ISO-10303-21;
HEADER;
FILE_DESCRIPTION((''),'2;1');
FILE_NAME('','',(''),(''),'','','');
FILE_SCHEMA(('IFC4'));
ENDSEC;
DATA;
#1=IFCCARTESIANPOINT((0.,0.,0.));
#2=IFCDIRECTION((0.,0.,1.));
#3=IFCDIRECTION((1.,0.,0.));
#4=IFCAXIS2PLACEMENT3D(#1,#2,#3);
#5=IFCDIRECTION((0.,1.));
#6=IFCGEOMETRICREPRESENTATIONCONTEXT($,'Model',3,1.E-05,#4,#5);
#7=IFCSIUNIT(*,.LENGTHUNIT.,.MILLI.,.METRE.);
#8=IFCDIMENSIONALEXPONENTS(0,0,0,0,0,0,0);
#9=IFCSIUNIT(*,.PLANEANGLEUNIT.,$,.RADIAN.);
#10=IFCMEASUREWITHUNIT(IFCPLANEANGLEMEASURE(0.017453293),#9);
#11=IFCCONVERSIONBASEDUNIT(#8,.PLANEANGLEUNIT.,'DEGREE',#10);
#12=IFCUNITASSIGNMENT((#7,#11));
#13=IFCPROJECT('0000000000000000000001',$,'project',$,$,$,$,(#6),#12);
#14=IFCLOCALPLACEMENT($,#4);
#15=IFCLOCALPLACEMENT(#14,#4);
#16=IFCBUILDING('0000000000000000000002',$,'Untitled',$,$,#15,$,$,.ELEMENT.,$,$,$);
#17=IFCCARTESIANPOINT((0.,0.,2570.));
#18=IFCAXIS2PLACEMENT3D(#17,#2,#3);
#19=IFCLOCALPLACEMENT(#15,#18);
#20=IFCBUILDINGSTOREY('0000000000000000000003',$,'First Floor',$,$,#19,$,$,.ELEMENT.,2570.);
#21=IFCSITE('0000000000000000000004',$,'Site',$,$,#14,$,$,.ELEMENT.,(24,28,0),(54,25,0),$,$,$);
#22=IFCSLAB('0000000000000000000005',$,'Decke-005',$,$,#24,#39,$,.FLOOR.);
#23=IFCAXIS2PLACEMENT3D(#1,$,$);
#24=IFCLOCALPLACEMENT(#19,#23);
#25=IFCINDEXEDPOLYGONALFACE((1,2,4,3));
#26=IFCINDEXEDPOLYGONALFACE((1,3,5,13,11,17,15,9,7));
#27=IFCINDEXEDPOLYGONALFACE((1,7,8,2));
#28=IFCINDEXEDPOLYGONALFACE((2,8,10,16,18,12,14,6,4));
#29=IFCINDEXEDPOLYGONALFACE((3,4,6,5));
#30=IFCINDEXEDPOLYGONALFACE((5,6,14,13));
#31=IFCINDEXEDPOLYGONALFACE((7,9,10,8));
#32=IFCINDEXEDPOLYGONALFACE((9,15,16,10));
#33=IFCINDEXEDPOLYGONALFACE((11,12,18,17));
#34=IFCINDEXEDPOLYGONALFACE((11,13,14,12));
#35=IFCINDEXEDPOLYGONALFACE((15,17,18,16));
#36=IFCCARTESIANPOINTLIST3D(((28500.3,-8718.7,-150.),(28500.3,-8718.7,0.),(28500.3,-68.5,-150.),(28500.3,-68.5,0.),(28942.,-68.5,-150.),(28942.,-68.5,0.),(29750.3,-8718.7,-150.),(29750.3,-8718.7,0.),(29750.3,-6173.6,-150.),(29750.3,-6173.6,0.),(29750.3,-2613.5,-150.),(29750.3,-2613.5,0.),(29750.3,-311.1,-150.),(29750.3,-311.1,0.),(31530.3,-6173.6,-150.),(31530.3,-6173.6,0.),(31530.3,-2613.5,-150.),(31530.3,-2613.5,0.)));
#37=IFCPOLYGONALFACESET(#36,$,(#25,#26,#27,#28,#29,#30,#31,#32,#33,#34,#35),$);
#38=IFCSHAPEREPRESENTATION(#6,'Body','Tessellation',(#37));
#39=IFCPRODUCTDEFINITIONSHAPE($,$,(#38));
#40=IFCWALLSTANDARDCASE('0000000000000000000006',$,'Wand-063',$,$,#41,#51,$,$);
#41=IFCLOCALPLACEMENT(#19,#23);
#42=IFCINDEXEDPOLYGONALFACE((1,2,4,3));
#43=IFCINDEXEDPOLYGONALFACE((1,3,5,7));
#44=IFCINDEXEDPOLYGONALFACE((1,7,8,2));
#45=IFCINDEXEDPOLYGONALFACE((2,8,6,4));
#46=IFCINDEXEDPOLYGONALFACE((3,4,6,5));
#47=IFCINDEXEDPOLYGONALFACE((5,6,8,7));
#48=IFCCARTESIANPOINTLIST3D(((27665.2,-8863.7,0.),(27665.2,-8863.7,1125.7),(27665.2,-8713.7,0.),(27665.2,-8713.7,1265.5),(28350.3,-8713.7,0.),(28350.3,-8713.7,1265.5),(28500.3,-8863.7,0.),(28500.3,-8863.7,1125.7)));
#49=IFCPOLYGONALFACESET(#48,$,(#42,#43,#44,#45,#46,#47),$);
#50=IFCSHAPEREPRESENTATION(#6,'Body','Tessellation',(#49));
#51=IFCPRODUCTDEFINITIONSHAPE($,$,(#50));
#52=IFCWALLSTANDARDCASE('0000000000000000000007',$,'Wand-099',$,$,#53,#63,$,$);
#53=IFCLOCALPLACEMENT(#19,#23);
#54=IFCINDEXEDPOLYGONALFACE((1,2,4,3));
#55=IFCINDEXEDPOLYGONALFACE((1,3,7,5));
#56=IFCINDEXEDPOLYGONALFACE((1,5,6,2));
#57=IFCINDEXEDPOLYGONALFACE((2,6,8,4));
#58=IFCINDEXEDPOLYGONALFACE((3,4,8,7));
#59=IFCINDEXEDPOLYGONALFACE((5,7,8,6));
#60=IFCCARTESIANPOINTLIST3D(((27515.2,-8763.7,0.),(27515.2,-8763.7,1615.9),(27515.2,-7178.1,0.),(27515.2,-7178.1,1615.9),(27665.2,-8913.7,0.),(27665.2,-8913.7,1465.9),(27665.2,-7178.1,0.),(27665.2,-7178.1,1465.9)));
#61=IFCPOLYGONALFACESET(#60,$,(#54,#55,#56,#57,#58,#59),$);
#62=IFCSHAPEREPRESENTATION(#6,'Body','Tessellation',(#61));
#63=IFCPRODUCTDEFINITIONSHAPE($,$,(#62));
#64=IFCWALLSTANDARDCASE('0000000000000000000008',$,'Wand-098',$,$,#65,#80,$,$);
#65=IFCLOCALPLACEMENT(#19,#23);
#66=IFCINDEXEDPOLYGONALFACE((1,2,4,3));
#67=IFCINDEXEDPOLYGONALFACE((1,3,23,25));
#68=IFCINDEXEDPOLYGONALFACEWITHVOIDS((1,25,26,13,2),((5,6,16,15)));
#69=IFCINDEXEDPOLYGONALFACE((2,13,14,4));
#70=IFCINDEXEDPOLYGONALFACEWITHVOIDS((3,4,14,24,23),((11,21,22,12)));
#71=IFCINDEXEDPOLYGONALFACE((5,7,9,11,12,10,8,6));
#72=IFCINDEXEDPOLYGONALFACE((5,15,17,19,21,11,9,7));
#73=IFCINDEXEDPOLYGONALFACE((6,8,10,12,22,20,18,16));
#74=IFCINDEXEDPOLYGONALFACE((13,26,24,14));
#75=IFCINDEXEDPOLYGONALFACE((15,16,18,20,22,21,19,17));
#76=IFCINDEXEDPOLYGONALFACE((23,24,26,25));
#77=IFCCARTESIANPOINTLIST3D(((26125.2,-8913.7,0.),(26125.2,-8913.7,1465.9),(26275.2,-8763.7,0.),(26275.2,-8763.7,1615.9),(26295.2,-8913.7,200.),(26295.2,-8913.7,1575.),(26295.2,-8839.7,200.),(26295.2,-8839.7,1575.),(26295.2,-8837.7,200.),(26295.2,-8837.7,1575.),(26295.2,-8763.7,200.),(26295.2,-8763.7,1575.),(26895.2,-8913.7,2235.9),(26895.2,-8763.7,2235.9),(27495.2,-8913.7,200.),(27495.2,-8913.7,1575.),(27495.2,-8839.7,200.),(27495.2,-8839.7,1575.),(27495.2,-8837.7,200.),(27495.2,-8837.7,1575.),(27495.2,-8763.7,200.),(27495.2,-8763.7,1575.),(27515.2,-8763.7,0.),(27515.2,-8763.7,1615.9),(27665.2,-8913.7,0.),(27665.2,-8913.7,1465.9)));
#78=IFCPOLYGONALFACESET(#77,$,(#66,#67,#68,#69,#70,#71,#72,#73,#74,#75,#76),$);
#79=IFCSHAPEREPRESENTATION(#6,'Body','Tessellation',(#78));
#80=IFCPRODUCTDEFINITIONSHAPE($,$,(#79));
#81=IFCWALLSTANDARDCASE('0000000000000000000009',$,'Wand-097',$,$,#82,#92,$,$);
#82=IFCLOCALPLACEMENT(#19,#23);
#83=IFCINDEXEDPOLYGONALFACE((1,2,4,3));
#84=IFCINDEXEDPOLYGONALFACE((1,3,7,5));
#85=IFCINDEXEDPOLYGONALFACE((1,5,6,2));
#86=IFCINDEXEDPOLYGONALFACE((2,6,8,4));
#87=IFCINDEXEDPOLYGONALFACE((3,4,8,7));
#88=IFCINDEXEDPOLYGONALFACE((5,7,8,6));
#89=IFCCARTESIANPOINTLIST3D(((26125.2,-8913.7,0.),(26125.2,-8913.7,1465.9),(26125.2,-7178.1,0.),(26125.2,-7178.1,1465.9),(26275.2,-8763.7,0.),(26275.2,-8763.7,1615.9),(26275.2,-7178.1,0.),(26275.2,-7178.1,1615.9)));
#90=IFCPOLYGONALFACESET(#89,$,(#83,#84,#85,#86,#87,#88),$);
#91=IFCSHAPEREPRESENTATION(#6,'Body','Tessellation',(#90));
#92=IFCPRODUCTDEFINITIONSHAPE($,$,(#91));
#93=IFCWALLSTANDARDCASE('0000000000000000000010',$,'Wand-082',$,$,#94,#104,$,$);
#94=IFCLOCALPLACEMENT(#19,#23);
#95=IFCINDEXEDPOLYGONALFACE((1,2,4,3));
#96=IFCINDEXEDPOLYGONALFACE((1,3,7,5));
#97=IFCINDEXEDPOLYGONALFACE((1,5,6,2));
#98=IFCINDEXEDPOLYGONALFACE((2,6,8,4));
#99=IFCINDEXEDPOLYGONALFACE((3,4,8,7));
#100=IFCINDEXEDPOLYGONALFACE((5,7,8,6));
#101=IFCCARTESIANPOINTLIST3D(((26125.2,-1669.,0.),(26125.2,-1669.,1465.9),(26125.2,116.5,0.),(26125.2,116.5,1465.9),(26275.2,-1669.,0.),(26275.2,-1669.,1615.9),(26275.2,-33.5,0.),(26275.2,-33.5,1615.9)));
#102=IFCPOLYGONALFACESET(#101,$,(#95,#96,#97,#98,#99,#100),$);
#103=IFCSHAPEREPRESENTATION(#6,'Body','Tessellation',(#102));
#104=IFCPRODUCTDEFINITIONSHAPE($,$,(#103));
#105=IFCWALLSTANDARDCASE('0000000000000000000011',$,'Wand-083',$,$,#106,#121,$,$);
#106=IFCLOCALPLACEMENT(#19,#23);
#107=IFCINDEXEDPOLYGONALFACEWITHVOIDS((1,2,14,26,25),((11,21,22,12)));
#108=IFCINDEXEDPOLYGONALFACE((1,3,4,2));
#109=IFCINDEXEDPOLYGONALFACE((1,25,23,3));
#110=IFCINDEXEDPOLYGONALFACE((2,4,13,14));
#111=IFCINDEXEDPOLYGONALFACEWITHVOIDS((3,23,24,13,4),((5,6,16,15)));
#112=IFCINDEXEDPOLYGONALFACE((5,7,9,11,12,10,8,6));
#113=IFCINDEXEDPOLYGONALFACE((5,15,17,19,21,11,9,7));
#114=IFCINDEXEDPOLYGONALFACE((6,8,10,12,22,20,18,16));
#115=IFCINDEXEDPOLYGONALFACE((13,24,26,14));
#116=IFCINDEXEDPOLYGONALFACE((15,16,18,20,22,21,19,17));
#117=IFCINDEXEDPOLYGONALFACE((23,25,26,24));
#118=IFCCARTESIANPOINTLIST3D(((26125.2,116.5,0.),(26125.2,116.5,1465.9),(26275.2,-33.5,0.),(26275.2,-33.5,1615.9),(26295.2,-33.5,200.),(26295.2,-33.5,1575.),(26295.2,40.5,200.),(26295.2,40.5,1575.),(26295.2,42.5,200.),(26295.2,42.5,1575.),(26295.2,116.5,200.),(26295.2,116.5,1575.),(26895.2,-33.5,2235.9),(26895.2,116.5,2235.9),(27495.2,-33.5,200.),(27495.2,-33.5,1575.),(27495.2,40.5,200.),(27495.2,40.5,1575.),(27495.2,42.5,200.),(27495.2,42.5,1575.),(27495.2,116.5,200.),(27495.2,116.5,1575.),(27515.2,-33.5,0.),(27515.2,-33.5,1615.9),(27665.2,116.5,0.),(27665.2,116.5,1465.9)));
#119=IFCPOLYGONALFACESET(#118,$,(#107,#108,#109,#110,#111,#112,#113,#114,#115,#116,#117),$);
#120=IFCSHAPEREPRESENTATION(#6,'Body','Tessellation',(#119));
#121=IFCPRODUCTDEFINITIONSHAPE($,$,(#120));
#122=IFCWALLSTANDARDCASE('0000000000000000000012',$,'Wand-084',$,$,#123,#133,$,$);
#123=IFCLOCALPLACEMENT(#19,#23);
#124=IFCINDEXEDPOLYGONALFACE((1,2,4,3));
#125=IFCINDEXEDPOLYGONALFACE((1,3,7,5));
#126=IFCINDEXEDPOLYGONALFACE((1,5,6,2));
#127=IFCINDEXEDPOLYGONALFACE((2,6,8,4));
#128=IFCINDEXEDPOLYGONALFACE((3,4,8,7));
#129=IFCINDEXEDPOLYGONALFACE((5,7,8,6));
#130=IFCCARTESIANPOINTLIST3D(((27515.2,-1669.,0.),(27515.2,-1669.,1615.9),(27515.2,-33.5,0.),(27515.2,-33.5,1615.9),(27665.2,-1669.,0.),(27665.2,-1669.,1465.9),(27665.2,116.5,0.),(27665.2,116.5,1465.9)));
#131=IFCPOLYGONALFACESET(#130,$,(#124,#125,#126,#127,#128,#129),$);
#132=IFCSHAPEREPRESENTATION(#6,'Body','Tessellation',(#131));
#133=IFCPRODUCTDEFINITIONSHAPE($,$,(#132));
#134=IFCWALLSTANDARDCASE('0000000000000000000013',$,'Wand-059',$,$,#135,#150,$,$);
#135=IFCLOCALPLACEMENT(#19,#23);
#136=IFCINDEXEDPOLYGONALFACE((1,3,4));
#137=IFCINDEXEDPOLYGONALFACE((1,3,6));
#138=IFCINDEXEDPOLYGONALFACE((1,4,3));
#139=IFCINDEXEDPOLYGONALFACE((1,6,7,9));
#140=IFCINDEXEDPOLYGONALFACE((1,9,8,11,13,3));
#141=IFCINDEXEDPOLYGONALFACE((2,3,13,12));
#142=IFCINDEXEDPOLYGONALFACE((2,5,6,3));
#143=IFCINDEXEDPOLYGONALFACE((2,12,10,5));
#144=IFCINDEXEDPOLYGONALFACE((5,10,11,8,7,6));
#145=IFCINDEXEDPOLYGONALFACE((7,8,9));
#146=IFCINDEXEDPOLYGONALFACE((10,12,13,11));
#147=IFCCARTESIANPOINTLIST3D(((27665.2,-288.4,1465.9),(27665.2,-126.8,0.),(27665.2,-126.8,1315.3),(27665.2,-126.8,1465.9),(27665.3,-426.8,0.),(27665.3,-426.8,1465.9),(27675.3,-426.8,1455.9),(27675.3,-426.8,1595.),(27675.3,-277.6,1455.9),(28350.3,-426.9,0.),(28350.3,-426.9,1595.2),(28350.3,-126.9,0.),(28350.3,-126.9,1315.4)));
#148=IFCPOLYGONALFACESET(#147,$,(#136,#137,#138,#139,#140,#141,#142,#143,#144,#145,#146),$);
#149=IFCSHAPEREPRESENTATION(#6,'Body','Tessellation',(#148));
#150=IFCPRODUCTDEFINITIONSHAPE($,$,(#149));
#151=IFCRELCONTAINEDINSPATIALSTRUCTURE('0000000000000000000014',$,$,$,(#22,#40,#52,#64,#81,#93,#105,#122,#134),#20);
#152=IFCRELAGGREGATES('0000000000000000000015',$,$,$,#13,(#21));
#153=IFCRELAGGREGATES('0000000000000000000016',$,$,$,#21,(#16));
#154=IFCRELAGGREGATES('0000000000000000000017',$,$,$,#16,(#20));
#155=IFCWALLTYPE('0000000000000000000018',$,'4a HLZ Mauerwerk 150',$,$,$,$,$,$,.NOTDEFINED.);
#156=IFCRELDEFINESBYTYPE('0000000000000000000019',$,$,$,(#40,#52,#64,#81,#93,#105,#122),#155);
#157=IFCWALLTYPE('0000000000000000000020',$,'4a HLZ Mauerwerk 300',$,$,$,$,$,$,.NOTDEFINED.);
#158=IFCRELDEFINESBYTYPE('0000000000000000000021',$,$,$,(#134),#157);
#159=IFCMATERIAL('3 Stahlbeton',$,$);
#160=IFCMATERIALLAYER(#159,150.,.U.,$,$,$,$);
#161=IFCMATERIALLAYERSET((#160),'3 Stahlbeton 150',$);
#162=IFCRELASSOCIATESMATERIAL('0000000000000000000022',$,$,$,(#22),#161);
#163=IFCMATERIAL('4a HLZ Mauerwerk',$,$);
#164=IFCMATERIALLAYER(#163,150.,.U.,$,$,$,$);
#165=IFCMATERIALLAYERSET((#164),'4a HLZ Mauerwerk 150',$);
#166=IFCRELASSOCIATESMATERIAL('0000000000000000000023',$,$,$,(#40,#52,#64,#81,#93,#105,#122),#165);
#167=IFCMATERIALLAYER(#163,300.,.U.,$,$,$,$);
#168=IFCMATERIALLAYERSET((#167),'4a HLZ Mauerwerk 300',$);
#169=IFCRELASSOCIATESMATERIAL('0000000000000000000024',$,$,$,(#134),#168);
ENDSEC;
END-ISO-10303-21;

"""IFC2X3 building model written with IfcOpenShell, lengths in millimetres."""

from ifc_helpers import new_model, entity, si_unit, converted_unit, direction, frame, origin_with_axes, origin_2d_with_axis, place, context, project, spatial, polyline, rectangle, outline, extrude, clip, halfspace, bounded_halfspace, material, layer, layer_set, layer_usage, type_object, element, save


model = new_model("IFC2X3")

# Units and contexts
model_context = context("Model", 3, precision=1e-05, world=origin_with_axes(), true_north=direction((0.0, 1.0)))
ifc_project = project(units=[si_unit("LENGTHUNIT", "METRE", prefix="MILLI"), converted_unit("PLANEANGLEUNIT", "DEGREE", entity("IfcPlaneAngleMeasure", 0.017453293), si_unit("PLANEANGLEUNIT", "RADIAN"), dimensions=[0, 0, 0, 0, 0, 0, 0])], contexts=[model_context])

# Site, building, storey
site_placement = place(None, origin_with_axes())
site = spatial("IfcSite", under=ifc_project, at=site_placement, Name="Site", CompositionType="ELEMENT", RefLatitude=(24, 28, 0), RefLongitude=(54, 25, 0))
building_placement = place(site_placement, origin_with_axes())
building = spatial("IfcBuilding", under=site, at=building_placement, Name="Untitled", CompositionType="ELEMENT")
storey_placement = place(building_placement, frame((0.0, 0.0, 2570.0), z_axis=(0.0, 0.0, 1.0), x_axis=(1.0, 0.0, 0.0)))
storey = spatial("IfcBuildingStorey", under=building, at=storey_placement, Name="First Floor", CompositionType="ELEMENT", Elevation=2570.0)

# Shared definitions
ifc_material_1 = material(Name="3 Stahlbeton")

# Slab
ifc_layer_1 = layer(ifc_material_1, 150.0, ventilated="UNKNOWN")
ifc_layer_set_1 = layer_set([ifc_layer_1], Name="3 Stahlbeton 150")
ifc_layer_usage_1 = layer_usage(ifc_layer_set_1, "AXIS3", "NEGATIVE", 150.0)
slab_placement = place(storey_placement, frame((28500.3, -68.5, -150.0), z_axis=(0.0, 0.0, 1.0), x_axis=(1.0, 0.0, 0.0)))
element("IfcSlab", 1, at=slab_placement, inside=storey, material=ifc_layer_usage_1, Name="Decke-005", PredefinedType="FLOOR", context=model_context, shape_type="SweptSolid", body=[
    extrude(outline(polyline([(0.0, 0.0), (0.0, -8650.2), (1250.0, -8650.2), (1250.0, -6105.1), (3030.1, -6105.1), (3030.1, -2545.1), (1250.0, -2545.1), (1250.0, -242.6), (441.7, 0.0), (0.0, 0.0)])), origin_with_axes(), (0.0, 0.0, 1.0), 150.0),
])

# Wall
ifc_material_2 = material(Name="4a HLZ Mauerwerk")
ifc_layer_2 = layer(ifc_material_2, 150.0, ventilated="UNKNOWN")
ifc_layer_set_2 = layer_set([ifc_layer_2], Name="4a HLZ Mauerwerk 150")
ifc_layer_usage_2 = layer_usage(ifc_layer_set_2, "AXIS2", "POSITIVE", 0.0)
wall_type_1 = type_object("IfcWallType", Name="4a HLZ Mauerwerk 150", PredefinedType="NOTDEFINED")
wall_1_placement = place(storey_placement, frame((27665.2, -8863.7, 0.0), z_axis=(0.0, 0.0, 1.0), x_axis=(1.0, 0.0, 0.0)))
element("IfcWallStandardCase", 2, at=wall_1_placement, inside=storey, type_object=wall_type_1, material=ifc_layer_usage_2, Name="Wand-063", context=model_context, shape_type="Clipping", body=[
    clip(extrude(outline(polyline([(0.0, 0.0), (835.0, 0.0), (685.0, 150.0), (0.0, 150.0), (0.0, 0.0)])), origin_with_axes(), (0.0, 0.0, 1.0), 5316.0), bounded_halfspace(frame((0.0, -561.5, 602.1), z_axis=(0.0, 0.681998, -0.731354), x_axis=(0.0, -0.731354, -0.681998)), True, origin_with_axes(), polyline([(0.0, 0.0), (835.0, 0.0), (835.0, 150.0), (0.0, 150.0), (0.0, 0.0)]))),
])

# Wall
ifc_layer_usage_3 = layer_usage(ifc_layer_set_2, "AXIS2", "POSITIVE", 0.0)
wall_2_placement = place(storey_placement, frame((27665.2, -8913.7, 0.0), z_axis=(0.0, 0.0, 1.0), x_axis=(0.0, 1.0, 0.0)))
element("IfcWallStandardCase", 3, at=wall_2_placement, inside=storey, type_object=wall_type_1, material=ifc_layer_usage_3, Name="Wand-099", context=model_context, shape_type="Clipping", body=[
    clip(extrude(outline(polyline([(0.0, 0.0), (1735.6, 0.0), (1735.6, 150.0), (150.0, 150.0), (0.0, 0.0)])), origin_with_axes(), (0.0, 0.0, 1.0), 5316.0), halfspace(frame((0.0, -733.0, 733.0), z_axis=(0.0, 0.707107, -0.707107), x_axis=(0.0, -0.707107, -0.707107)), True)),
])

# Wall, opening
ifc_layer_usage_4 = layer_usage(ifc_layer_set_2, "AXIS2", "POSITIVE", 0.0)
wall_3_placement = place(storey_placement, frame((26125.2, -8913.7, 0.0), z_axis=(0.0, 0.0, 1.0), x_axis=(1.0, 0.0, 0.0)))
wall_3 = element("IfcWallStandardCase", 4, at=wall_3_placement, inside=storey, type_object=wall_type_1, material=ifc_layer_usage_4, Name="Wand-098", context=model_context, shape_type="Clipping", body=[
    clip(clip(extrude(outline(polyline([(0.0, 0.0), (1540.0, 0.0), (1390.0, 150.0), (150.0, 150.0), (0.0, 0.0)])), origin_with_axes(), (0.0, 0.0, 1.0), 5316.0), bounded_halfspace(frame((1503.0, 0.0, 1503.0), z_axis=(-0.707107, 0.0, -0.707107), x_axis=(0.707107, 0.0, -0.707107)), True, origin_with_axes(), polyline([(770.0, 0.0), (1540.0, 0.0), (1540.0, 150.0), (770.0, 150.0), (770.0, 0.0)]))), bounded_halfspace(frame((-733.0, 0.0, 733.0), z_axis=(0.707107, 0.0, -0.707107), x_axis=(0.707107, 0.0, 0.707107)), True, origin_with_axes(), polyline([(0.0, 0.0), (770.0, 0.0), (770.0, 150.0), (0.0, 150.0), (0.0, 0.0)]))),
])
opening_1_placement = place(wall_3_placement, frame((770.0, 0.0, 200.0), z_axis=(0.0, 0.0, 1.0), x_axis=(1.0, 0.0, 0.0)))
element("IfcOpeningElement", 5, at=opening_1_placement, cuts=wall_3, context=model_context, shape_type="SweptSolid", body=[
    extrude(rectangle(XDim=1200.0, YDim=1375.0, at=origin_2d_with_axis()), frame((0.0, -226.0, 687.5), z_axis=(0.0, 1.0, 0.0), x_axis=(1.0, 0.0, 0.0)), (0.0, 0.0, 1.0), 302.0),
    extrude(rectangle(XDim=1200.0, YDim=1375.0, at=origin_2d_with_axis()), frame((0.0, 376.0, 687.5), z_axis=(0.0, -1.0, 0.0), x_axis=(1.0, 0.0, 0.0)), (0.0, 0.0, 1.0), 302.0),
])

# Walls
ifc_layer_usage_5 = layer_usage(ifc_layer_set_2, "AXIS2", "NEGATIVE", 0.0)
wall_4_placement = place(storey_placement, frame((26125.2, -8913.7, 0.0), z_axis=(0.0, 0.0, 1.0), x_axis=(0.0, 1.0, 0.0)))
element("IfcWallStandardCase", 6, at=wall_4_placement, inside=storey, type_object=wall_type_1, material=ifc_layer_usage_5, Name="Wand-097", context=model_context, shape_type="Clipping", body=[
    clip(extrude(outline(polyline([(150.0, -150.0), (1735.6, -150.0), (1735.6, 0.0), (0.0, 0.0), (150.0, -150.0)])), origin_with_axes(), (0.0, 0.0, 1.0), 5316.0), halfspace(frame((0.0, 733.0, 733.0), z_axis=(0.0, -0.707107, -0.707107), x_axis=(0.0, -0.707107, 0.707107)), True)),
])
ifc_layer_usage_6 = layer_usage(ifc_layer_set_2, "AXIS2", "POSITIVE", 0.0)
wall_5_placement = place(storey_placement, frame((26125.2, 116.5, 0.0), z_axis=(0.0, 0.0, 1.0), x_axis=(0.0, -1.0, 0.0)))
element("IfcWallStandardCase", 7, at=wall_5_placement, inside=storey, type_object=wall_type_1, material=ifc_layer_usage_6, Name="Wand-082", context=model_context, shape_type="Clipping", body=[
    clip(extrude(outline(polyline([(0.0, 0.0), (1785.6, 0.0), (1785.6, 150.0), (150.0, 150.0), (0.0, 0.0)])), origin_with_axes(), (0.0, 0.0, 1.0), 5316.0), halfspace(frame((0.0, -733.0, 733.0), z_axis=(0.0, 0.707107, -0.707107), x_axis=(0.0, -0.707107, -0.707107)), True)),
])

# Wall, opening
ifc_layer_usage_7 = layer_usage(ifc_layer_set_2, "AXIS2", "NEGATIVE", 0.0)
wall_6_placement = place(storey_placement, frame((26125.2, 116.5, 0.0), z_axis=(0.0, 0.0, 1.0), x_axis=(1.0, 0.0, 0.0)))
wall_6 = element("IfcWallStandardCase", 8, at=wall_6_placement, inside=storey, type_object=wall_type_1, material=ifc_layer_usage_7, Name="Wand-083", context=model_context, shape_type="Clipping", body=[
    clip(clip(extrude(outline(polyline([(150.0, -150.0), (1390.0, -150.0), (1540.0, 0.0), (0.0, 0.0), (150.0, -150.0)])), origin_with_axes(), (0.0, 0.0, 1.0), 5316.0), bounded_halfspace(frame((1503.0, 0.0, 1503.0), z_axis=(-0.707107, 0.0, -0.707107), x_axis=(0.707107, 0.0, -0.707107)), True, origin_with_axes(), polyline([(770.0, -150.0), (1540.0, -150.0), (1540.0, 0.0), (770.0, 0.0), (770.0, -150.0)]))), bounded_halfspace(frame((-733.0, 0.0, 733.0), z_axis=(0.707107, 0.0, -0.707107), x_axis=(0.707107, 0.0, 0.707107)), True, origin_with_axes(), polyline([(0.0, -150.0), (770.0, -150.0), (770.0, 0.0), (0.0, 0.0), (0.0, -150.0)]))),
])
opening_2_placement = place(wall_6_placement, frame((770.0, 0.0, 200.0), z_axis=(0.0, 0.0, 1.0), x_axis=(1.0, 0.0, 0.0)))
element("IfcOpeningElement", 9, at=opening_2_placement, cuts=wall_6, context=model_context, shape_type="SweptSolid", body=[
    extrude(rectangle(XDim=1200.0, YDim=1375.0, at=origin_2d_with_axis()), frame((0.0, 226.0, 687.5), z_axis=(0.0, -1.0, 0.0), x_axis=(1.0, 0.0, 0.0)), (0.0, 0.0, 1.0), 302.0),
    extrude(rectangle(XDim=1200.0, YDim=1375.0, at=origin_2d_with_axis()), frame((0.0, -376.0, 687.5), z_axis=(0.0, 1.0, 0.0), x_axis=(1.0, 0.0, 0.0)), (0.0, 0.0, 1.0), 302.0),
])

# Walls
ifc_layer_usage_8 = layer_usage(ifc_layer_set_2, "AXIS2", "NEGATIVE", 0.0)
wall_7_placement = place(storey_placement, frame((27665.2, 116.5, 0.0), z_axis=(0.0, 0.0, 1.0), x_axis=(0.0, -1.0, 0.0)))
element("IfcWallStandardCase", 10, at=wall_7_placement, inside=storey, type_object=wall_type_1, material=ifc_layer_usage_8, Name="Wand-084", context=model_context, shape_type="Clipping", body=[
    clip(extrude(outline(polyline([(150.0, -150.0), (1785.6, -150.0), (1785.6, 0.0), (0.0, 0.0), (150.0, -150.0)])), origin_with_axes(), (0.0, 0.0, 1.0), 5316.0), halfspace(frame((0.0, 733.0, 733.0), z_axis=(0.0, -0.707107, -0.707107), x_axis=(0.0, -0.707107, 0.707107)), True)),
])
ifc_layer_3 = layer(ifc_material_2, 300.0, ventilated="UNKNOWN")
ifc_layer_set_3 = layer_set([ifc_layer_3], Name="4a HLZ Mauerwerk 300")
wall_type_2 = type_object("IfcWallType", Name="4a HLZ Mauerwerk 300", PredefinedType="NOTDEFINED")
ifc_layer_usage_9 = layer_usage(ifc_layer_set_3, "AXIS2", "NEGATIVE", 0.0)
wall_8_placement = place(storey_placement, frame((27665.2, -126.8, 0.0), z_axis=(0.0, 0.0, 1.0), x_axis=(1.0, -0.000191, 0.0)))
element("IfcWallStandardCase", 11, at=wall_8_placement, inside=storey, type_object=wall_type_2, material=ifc_layer_usage_9, Name="Wand-059", context=model_context, shape_type="Clipping", body=[
    clip(clip(extrude(outline(polyline([(0.1, -300.0), (685.1, -300.0), (685.0, 0.0), (0.0, 0.0), (0.1, -300.0)])), origin_with_axes(), (0.0, 0.0, 1.0), 5316.0), bounded_halfspace(frame((733.0, 0.1, 733.0), z_axis=(-0.707107, -0.000135, -0.707107), x_axis=(0.707107, 0.0, -0.707107)), True, origin_with_axes(), polyline([(0.0, -300.0), (10.1, -300.0), (10.0, 0.0), (0.0, 0.0), (0.0, -300.0)]))), bounded_halfspace(frame((-0.1, 656.0, 703.5), z_axis=(0.00013, -0.681998, -0.731354), x_axis=(0.0, -0.731354, 0.681998)), True, origin_with_axes(), polyline([(0.0, -300.0), (685.1, -300.0), (685.1, 0.0), (0.0, 0.0), (0.0, -300.0)]))),
])

save(model, "model.ifc")
